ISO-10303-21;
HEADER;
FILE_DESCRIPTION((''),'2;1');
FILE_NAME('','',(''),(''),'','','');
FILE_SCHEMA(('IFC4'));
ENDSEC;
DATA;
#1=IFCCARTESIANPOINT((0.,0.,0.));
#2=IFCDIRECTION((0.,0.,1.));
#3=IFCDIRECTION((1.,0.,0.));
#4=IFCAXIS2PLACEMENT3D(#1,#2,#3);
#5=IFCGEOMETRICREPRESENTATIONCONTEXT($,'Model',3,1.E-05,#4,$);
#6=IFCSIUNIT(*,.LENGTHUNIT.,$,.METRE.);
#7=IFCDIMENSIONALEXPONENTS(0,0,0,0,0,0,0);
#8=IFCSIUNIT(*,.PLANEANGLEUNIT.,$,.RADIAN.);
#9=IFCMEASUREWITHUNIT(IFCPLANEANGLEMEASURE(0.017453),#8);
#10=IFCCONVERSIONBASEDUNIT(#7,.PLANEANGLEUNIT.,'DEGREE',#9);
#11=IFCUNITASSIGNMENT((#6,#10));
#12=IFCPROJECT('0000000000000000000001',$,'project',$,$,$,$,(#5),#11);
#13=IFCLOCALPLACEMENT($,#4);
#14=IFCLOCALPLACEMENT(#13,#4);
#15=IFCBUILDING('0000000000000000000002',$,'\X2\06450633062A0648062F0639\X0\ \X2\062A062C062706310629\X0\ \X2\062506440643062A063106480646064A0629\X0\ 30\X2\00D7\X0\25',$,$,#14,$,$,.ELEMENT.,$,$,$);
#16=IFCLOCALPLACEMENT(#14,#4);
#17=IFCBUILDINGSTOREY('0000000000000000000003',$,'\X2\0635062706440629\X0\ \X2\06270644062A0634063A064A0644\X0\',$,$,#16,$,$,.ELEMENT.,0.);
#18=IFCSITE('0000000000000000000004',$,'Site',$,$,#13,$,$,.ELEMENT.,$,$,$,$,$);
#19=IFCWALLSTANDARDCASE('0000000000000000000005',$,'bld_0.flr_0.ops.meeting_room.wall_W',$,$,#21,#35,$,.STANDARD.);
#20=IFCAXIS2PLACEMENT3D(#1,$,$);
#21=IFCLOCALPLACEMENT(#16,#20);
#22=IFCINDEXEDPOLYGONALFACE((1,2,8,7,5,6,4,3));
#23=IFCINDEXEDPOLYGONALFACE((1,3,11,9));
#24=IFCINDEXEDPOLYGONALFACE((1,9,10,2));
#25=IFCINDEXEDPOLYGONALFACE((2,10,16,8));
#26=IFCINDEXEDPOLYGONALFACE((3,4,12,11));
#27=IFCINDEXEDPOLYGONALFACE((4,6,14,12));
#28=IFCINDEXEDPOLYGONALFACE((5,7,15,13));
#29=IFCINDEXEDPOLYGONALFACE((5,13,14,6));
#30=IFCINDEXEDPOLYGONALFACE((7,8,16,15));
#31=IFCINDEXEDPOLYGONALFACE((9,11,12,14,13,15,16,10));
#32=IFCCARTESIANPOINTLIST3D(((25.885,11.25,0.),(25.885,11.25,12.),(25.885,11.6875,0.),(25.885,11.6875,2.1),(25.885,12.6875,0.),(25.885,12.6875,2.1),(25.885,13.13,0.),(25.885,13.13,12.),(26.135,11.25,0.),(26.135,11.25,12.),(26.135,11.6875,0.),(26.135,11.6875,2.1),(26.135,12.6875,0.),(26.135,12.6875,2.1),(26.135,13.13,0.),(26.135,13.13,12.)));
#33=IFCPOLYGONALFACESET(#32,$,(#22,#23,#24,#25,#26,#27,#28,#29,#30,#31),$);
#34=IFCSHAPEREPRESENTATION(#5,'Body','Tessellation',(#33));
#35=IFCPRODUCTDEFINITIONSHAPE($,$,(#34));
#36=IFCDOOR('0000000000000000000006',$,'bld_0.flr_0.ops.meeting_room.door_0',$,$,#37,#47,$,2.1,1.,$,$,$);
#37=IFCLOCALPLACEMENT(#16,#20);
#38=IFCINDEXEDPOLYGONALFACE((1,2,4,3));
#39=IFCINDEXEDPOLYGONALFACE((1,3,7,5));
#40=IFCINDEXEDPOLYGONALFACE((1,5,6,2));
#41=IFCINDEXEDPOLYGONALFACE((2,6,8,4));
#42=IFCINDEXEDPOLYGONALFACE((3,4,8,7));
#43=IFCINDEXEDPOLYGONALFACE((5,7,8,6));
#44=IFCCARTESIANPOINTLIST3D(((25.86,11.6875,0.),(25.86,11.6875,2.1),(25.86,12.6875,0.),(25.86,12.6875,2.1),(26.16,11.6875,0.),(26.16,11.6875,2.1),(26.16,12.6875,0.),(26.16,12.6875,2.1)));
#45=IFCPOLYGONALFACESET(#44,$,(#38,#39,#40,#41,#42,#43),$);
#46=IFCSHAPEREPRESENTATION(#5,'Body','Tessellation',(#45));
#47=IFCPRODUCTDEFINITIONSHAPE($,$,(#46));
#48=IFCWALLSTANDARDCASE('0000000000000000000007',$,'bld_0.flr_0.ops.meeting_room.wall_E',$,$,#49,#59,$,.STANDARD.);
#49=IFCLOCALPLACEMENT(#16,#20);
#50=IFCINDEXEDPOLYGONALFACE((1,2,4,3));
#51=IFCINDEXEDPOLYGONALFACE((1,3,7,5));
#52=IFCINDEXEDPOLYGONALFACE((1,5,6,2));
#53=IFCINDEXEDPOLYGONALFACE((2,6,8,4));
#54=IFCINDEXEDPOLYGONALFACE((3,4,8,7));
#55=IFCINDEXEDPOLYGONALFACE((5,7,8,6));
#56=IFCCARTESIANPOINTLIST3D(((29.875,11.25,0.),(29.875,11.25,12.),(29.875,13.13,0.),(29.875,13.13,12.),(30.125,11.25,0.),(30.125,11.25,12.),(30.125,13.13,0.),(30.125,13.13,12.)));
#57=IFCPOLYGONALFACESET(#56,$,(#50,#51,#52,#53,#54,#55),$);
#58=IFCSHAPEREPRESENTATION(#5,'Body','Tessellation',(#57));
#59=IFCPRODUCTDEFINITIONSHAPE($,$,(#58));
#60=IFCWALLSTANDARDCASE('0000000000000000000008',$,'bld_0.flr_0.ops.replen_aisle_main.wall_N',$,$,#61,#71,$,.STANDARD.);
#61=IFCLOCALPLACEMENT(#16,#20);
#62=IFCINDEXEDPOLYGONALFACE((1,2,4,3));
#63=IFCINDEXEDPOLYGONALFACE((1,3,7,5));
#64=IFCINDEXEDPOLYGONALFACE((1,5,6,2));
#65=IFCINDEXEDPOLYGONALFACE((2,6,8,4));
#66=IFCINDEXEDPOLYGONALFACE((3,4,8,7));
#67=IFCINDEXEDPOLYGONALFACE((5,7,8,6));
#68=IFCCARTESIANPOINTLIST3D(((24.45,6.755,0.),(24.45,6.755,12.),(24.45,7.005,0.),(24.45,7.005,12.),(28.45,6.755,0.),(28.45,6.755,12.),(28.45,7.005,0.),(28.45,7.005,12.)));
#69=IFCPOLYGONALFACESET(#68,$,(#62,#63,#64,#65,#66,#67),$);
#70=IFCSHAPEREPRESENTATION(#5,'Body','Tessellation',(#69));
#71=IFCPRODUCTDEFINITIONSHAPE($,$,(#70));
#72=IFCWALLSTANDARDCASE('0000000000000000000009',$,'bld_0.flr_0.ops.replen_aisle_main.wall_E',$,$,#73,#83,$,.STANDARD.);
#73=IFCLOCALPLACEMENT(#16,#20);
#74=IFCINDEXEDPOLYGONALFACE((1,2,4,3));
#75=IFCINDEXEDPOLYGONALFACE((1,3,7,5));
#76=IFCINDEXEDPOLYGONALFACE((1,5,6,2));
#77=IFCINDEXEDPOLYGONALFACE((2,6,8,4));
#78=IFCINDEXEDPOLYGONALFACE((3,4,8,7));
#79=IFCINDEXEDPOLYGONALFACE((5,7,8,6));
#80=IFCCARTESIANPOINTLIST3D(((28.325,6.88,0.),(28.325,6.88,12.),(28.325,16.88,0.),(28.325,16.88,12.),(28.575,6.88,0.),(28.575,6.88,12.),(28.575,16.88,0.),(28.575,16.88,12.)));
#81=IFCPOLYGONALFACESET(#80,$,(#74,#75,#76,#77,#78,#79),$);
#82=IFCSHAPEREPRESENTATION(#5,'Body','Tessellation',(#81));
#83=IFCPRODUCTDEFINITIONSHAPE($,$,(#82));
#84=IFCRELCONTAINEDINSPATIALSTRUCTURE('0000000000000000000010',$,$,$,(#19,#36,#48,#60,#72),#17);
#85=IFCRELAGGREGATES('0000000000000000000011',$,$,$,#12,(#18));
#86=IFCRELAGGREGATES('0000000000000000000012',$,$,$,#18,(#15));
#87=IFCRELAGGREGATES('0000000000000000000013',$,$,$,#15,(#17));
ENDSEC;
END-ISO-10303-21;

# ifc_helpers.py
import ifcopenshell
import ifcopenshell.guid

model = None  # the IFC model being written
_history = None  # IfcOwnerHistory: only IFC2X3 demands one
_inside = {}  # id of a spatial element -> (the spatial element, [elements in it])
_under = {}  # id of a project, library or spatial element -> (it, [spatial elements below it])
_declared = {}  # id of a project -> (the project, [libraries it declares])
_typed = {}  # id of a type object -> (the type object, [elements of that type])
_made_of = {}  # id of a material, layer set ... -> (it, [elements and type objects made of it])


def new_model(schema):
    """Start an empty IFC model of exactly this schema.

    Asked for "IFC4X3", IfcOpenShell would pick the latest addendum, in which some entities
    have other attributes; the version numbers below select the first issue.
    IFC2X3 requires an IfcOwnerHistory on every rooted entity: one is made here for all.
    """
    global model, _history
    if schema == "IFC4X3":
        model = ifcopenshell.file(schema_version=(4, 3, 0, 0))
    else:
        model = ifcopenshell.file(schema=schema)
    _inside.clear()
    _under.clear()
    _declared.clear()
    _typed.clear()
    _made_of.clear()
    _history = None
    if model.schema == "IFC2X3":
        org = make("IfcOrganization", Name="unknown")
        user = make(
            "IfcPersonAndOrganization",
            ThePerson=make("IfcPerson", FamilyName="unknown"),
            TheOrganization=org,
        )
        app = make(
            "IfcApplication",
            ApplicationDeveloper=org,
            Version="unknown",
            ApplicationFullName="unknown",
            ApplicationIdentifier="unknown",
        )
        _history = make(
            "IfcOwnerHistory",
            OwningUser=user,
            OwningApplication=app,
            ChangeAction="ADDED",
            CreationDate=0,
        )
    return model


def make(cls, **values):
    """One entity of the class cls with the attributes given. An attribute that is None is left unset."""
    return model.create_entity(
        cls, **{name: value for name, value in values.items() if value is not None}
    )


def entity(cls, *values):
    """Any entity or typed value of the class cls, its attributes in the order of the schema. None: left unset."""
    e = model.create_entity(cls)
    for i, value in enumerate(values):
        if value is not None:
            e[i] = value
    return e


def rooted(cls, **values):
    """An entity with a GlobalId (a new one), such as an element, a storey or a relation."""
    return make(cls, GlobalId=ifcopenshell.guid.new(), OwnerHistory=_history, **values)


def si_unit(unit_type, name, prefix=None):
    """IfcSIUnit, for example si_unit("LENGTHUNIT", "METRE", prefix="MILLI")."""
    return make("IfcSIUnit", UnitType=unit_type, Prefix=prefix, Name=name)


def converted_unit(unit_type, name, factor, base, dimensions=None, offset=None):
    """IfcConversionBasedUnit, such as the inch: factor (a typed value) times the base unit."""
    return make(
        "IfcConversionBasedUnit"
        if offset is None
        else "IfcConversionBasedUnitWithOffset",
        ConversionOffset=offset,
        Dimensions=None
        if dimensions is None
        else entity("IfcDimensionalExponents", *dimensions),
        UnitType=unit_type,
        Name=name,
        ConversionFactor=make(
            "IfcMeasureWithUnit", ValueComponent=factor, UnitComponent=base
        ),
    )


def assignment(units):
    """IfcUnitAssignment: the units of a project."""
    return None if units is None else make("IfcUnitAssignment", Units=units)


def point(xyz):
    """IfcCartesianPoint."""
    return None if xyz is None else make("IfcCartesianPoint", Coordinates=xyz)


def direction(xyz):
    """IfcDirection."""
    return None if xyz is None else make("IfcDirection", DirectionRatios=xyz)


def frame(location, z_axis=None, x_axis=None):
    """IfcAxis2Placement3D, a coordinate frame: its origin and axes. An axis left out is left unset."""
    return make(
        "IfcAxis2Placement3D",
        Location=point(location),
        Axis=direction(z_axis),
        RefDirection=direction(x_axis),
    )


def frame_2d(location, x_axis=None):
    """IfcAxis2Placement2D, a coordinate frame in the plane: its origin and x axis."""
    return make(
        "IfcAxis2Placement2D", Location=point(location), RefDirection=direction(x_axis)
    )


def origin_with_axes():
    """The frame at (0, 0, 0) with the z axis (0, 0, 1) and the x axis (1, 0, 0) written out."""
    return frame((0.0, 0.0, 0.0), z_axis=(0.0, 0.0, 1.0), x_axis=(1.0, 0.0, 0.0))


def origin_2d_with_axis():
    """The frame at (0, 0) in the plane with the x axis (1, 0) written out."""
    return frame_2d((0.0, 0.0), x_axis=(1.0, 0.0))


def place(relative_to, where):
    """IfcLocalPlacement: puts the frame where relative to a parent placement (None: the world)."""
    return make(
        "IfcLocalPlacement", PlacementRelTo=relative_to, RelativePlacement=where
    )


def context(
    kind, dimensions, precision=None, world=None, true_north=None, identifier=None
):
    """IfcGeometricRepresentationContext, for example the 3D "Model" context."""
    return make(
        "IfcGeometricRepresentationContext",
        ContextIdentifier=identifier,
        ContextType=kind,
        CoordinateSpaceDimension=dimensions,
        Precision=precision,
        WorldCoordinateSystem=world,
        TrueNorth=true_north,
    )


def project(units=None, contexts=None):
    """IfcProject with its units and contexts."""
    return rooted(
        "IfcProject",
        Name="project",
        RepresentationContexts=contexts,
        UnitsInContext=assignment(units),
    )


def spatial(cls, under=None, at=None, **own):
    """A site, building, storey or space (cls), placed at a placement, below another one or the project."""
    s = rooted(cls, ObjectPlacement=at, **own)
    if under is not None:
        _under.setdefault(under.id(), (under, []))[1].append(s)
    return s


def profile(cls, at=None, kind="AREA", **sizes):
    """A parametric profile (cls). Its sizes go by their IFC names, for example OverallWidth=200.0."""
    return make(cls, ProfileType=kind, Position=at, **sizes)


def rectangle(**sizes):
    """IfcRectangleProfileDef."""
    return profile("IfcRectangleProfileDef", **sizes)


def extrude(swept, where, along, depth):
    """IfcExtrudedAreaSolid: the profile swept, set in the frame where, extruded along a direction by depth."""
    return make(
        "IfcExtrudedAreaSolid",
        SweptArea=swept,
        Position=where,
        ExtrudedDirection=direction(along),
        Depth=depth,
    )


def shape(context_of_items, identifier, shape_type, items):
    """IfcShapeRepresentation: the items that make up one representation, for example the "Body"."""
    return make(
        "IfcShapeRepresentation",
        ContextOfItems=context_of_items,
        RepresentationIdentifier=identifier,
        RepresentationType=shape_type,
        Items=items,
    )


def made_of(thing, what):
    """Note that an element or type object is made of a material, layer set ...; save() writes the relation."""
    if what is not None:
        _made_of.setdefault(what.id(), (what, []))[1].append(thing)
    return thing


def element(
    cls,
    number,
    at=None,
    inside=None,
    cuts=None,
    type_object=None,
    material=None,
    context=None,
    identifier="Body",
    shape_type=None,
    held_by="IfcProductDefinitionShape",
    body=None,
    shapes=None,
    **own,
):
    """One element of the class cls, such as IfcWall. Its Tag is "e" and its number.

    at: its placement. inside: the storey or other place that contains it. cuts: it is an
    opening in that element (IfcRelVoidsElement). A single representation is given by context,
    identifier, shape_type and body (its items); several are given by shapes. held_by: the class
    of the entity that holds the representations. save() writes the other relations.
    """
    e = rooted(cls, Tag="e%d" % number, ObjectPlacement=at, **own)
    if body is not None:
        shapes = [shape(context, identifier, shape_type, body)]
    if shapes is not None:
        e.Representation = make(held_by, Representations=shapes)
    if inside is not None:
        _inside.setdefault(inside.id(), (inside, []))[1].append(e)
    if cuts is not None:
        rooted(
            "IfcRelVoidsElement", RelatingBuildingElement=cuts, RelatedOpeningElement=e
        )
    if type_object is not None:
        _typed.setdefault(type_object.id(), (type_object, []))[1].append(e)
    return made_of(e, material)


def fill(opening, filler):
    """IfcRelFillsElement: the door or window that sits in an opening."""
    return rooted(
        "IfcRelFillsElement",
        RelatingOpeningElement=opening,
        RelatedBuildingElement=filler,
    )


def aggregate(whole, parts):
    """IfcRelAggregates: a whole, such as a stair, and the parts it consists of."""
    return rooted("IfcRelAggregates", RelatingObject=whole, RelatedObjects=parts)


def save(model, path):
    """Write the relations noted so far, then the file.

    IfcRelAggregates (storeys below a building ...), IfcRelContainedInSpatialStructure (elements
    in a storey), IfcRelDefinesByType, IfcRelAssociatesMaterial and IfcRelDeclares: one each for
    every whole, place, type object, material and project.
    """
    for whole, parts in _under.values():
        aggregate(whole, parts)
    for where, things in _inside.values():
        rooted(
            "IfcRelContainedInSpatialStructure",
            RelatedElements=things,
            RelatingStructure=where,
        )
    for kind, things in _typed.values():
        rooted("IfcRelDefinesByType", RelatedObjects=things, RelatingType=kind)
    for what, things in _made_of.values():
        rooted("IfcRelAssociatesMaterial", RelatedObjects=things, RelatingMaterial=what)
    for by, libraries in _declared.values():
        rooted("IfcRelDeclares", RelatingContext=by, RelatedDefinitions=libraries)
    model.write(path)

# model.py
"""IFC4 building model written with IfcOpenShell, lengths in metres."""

from ifc_helpers import new_model, entity, si_unit, converted_unit, frame, frame_2d, origin_with_axes, origin_2d_with_axis, place, context, project, spatial, rectangle, extrude, element, fill, save


model = new_model("IFC4")

# Units and contexts
model_context = context("Model", 3, precision=1e-05, world=origin_with_axes())
ifc_project = project(units=[si_unit("LENGTHUNIT", "METRE"), converted_unit("PLANEANGLEUNIT", "DEGREE", entity("IfcPlaneAngleMeasure", 0.017453), si_unit("PLANEANGLEUNIT", "RADIAN"), dimensions=[0, 0, 0, 0, 0, 0, 0])], contexts=[model_context])

# Site, building, storey
site_placement = place(None, origin_with_axes())
site = spatial("IfcSite", under=ifc_project, at=site_placement, Name="Site", CompositionType="ELEMENT")
building_placement = place(site_placement, origin_with_axes())
building = spatial("IfcBuilding", under=site, at=building_placement, Name="مستودع تجارة إلكترونية 30×25", CompositionType="ELEMENT")
storey_placement = place(building_placement, origin_with_axes())
storey = spatial("IfcBuildingStorey", under=building, at=storey_placement, Name="صالة التشغيل", CompositionType="ELEMENT", Elevation=0.0)

# Wall, opening, door
wall_1_placement = place(storey_placement, frame((26.01, 11.25, 0.0), z_axis=(0.0, 0.0, 1.0), x_axis=(0.0, 1.0, 0.0)))
wall_1 = element("IfcWallStandardCase", 1, at=wall_1_placement, inside=storey, Name="bld_0.flr_0.ops.meeting_room.wall_W", PredefinedType="STANDARD", context=model_context, shape_type="SweptSolid", body=[
    extrude(rectangle(XDim=1.88, YDim=0.25, at=frame_2d((0.94, 0.0), x_axis=(1.0, 0.0))), origin_with_axes(), (0.0, 0.0, 1.0), 12.0),
])
opening_1_placement = place(storey_placement, frame((26.01, 12.1875, 0.0), z_axis=(0.0, 0.0, 1.0), x_axis=(0.0, 1.0, 0.0)))
opening_1 = element("IfcOpeningElement", 2, at=opening_1_placement, cuts=wall_1, PredefinedType="OPENING", context=model_context, shape_type="SweptSolid", body=[
    extrude(rectangle(XDim=1.0, YDim=0.3, at=origin_2d_with_axis()), origin_with_axes(), (0.0, 0.0, 1.0), 2.1),
])
door_1_placement = place(storey_placement, frame((26.01, 12.1875, 0.0), z_axis=(0.0, 0.0, 1.0), x_axis=(0.0, 1.0, 0.0)))
door_1 = element("IfcDoor", 3, at=door_1_placement, inside=storey, Name="bld_0.flr_0.ops.meeting_room.door_0", OverallHeight=2.1, OverallWidth=1.0, context=model_context, shape_type="SweptSolid", body=[
    extrude(rectangle(XDim=1.0, YDim=0.3, at=origin_2d_with_axis()), origin_with_axes(), (0.0, 0.0, 1.0), 2.1),
])
fill(opening_1, door_1)

# Walls
wall_2_placement = place(storey_placement, frame((30.0, 11.25, 0.0), z_axis=(0.0, 0.0, 1.0), x_axis=(0.0, 1.0, 0.0)))
element("IfcWallStandardCase", 4, at=wall_2_placement, inside=storey, Name="bld_0.flr_0.ops.meeting_room.wall_E", PredefinedType="STANDARD", context=model_context, shape_type="SweptSolid", body=[
    extrude(rectangle(XDim=1.88, YDim=0.25, at=frame_2d((0.94, 0.0), x_axis=(1.0, 0.0))), origin_with_axes(), (0.0, 0.0, 1.0), 12.0),
])
wall_3_placement = place(storey_placement, frame((24.45, 6.88, 0.0), z_axis=(0.0, 0.0, 1.0), x_axis=(1.0, 0.0, 0.0)))
element("IfcWallStandardCase", 5, at=wall_3_placement, inside=storey, Name="bld_0.flr_0.ops.replen_aisle_main.wall_N", PredefinedType="STANDARD", context=model_context, shape_type="SweptSolid", body=[
    extrude(rectangle(XDim=4.0, YDim=0.25, at=frame_2d((2.0, 0.0), x_axis=(1.0, 0.0))), origin_with_axes(), (0.0, 0.0, 1.0), 12.0),
])
for number, where, z_axis, x_axis, name in (
    (6, (28.45, 6.88, 0.0), (0.0, 0.0, 1.0), (0.0, 1.0, 0.0), "bld_0.flr_0.ops.replen_aisle_main.wall_E"),
):
    element("IfcWallStandardCase", number, at=place(storey_placement, frame(where, z_axis=z_axis, x_axis=x_axis)), inside=storey, Name=name, PredefinedType="STANDARD", context=model_context, shape_type="SweptSolid", body=[
        extrude(rectangle(XDim=10.0, YDim=0.25, at=frame_2d((5.0, 0.0), x_axis=(1.0, 0.0))), origin_with_axes(), (0.0, 0.0, 1.0), 12.0),
    ])

save(model, "model.ifc")
